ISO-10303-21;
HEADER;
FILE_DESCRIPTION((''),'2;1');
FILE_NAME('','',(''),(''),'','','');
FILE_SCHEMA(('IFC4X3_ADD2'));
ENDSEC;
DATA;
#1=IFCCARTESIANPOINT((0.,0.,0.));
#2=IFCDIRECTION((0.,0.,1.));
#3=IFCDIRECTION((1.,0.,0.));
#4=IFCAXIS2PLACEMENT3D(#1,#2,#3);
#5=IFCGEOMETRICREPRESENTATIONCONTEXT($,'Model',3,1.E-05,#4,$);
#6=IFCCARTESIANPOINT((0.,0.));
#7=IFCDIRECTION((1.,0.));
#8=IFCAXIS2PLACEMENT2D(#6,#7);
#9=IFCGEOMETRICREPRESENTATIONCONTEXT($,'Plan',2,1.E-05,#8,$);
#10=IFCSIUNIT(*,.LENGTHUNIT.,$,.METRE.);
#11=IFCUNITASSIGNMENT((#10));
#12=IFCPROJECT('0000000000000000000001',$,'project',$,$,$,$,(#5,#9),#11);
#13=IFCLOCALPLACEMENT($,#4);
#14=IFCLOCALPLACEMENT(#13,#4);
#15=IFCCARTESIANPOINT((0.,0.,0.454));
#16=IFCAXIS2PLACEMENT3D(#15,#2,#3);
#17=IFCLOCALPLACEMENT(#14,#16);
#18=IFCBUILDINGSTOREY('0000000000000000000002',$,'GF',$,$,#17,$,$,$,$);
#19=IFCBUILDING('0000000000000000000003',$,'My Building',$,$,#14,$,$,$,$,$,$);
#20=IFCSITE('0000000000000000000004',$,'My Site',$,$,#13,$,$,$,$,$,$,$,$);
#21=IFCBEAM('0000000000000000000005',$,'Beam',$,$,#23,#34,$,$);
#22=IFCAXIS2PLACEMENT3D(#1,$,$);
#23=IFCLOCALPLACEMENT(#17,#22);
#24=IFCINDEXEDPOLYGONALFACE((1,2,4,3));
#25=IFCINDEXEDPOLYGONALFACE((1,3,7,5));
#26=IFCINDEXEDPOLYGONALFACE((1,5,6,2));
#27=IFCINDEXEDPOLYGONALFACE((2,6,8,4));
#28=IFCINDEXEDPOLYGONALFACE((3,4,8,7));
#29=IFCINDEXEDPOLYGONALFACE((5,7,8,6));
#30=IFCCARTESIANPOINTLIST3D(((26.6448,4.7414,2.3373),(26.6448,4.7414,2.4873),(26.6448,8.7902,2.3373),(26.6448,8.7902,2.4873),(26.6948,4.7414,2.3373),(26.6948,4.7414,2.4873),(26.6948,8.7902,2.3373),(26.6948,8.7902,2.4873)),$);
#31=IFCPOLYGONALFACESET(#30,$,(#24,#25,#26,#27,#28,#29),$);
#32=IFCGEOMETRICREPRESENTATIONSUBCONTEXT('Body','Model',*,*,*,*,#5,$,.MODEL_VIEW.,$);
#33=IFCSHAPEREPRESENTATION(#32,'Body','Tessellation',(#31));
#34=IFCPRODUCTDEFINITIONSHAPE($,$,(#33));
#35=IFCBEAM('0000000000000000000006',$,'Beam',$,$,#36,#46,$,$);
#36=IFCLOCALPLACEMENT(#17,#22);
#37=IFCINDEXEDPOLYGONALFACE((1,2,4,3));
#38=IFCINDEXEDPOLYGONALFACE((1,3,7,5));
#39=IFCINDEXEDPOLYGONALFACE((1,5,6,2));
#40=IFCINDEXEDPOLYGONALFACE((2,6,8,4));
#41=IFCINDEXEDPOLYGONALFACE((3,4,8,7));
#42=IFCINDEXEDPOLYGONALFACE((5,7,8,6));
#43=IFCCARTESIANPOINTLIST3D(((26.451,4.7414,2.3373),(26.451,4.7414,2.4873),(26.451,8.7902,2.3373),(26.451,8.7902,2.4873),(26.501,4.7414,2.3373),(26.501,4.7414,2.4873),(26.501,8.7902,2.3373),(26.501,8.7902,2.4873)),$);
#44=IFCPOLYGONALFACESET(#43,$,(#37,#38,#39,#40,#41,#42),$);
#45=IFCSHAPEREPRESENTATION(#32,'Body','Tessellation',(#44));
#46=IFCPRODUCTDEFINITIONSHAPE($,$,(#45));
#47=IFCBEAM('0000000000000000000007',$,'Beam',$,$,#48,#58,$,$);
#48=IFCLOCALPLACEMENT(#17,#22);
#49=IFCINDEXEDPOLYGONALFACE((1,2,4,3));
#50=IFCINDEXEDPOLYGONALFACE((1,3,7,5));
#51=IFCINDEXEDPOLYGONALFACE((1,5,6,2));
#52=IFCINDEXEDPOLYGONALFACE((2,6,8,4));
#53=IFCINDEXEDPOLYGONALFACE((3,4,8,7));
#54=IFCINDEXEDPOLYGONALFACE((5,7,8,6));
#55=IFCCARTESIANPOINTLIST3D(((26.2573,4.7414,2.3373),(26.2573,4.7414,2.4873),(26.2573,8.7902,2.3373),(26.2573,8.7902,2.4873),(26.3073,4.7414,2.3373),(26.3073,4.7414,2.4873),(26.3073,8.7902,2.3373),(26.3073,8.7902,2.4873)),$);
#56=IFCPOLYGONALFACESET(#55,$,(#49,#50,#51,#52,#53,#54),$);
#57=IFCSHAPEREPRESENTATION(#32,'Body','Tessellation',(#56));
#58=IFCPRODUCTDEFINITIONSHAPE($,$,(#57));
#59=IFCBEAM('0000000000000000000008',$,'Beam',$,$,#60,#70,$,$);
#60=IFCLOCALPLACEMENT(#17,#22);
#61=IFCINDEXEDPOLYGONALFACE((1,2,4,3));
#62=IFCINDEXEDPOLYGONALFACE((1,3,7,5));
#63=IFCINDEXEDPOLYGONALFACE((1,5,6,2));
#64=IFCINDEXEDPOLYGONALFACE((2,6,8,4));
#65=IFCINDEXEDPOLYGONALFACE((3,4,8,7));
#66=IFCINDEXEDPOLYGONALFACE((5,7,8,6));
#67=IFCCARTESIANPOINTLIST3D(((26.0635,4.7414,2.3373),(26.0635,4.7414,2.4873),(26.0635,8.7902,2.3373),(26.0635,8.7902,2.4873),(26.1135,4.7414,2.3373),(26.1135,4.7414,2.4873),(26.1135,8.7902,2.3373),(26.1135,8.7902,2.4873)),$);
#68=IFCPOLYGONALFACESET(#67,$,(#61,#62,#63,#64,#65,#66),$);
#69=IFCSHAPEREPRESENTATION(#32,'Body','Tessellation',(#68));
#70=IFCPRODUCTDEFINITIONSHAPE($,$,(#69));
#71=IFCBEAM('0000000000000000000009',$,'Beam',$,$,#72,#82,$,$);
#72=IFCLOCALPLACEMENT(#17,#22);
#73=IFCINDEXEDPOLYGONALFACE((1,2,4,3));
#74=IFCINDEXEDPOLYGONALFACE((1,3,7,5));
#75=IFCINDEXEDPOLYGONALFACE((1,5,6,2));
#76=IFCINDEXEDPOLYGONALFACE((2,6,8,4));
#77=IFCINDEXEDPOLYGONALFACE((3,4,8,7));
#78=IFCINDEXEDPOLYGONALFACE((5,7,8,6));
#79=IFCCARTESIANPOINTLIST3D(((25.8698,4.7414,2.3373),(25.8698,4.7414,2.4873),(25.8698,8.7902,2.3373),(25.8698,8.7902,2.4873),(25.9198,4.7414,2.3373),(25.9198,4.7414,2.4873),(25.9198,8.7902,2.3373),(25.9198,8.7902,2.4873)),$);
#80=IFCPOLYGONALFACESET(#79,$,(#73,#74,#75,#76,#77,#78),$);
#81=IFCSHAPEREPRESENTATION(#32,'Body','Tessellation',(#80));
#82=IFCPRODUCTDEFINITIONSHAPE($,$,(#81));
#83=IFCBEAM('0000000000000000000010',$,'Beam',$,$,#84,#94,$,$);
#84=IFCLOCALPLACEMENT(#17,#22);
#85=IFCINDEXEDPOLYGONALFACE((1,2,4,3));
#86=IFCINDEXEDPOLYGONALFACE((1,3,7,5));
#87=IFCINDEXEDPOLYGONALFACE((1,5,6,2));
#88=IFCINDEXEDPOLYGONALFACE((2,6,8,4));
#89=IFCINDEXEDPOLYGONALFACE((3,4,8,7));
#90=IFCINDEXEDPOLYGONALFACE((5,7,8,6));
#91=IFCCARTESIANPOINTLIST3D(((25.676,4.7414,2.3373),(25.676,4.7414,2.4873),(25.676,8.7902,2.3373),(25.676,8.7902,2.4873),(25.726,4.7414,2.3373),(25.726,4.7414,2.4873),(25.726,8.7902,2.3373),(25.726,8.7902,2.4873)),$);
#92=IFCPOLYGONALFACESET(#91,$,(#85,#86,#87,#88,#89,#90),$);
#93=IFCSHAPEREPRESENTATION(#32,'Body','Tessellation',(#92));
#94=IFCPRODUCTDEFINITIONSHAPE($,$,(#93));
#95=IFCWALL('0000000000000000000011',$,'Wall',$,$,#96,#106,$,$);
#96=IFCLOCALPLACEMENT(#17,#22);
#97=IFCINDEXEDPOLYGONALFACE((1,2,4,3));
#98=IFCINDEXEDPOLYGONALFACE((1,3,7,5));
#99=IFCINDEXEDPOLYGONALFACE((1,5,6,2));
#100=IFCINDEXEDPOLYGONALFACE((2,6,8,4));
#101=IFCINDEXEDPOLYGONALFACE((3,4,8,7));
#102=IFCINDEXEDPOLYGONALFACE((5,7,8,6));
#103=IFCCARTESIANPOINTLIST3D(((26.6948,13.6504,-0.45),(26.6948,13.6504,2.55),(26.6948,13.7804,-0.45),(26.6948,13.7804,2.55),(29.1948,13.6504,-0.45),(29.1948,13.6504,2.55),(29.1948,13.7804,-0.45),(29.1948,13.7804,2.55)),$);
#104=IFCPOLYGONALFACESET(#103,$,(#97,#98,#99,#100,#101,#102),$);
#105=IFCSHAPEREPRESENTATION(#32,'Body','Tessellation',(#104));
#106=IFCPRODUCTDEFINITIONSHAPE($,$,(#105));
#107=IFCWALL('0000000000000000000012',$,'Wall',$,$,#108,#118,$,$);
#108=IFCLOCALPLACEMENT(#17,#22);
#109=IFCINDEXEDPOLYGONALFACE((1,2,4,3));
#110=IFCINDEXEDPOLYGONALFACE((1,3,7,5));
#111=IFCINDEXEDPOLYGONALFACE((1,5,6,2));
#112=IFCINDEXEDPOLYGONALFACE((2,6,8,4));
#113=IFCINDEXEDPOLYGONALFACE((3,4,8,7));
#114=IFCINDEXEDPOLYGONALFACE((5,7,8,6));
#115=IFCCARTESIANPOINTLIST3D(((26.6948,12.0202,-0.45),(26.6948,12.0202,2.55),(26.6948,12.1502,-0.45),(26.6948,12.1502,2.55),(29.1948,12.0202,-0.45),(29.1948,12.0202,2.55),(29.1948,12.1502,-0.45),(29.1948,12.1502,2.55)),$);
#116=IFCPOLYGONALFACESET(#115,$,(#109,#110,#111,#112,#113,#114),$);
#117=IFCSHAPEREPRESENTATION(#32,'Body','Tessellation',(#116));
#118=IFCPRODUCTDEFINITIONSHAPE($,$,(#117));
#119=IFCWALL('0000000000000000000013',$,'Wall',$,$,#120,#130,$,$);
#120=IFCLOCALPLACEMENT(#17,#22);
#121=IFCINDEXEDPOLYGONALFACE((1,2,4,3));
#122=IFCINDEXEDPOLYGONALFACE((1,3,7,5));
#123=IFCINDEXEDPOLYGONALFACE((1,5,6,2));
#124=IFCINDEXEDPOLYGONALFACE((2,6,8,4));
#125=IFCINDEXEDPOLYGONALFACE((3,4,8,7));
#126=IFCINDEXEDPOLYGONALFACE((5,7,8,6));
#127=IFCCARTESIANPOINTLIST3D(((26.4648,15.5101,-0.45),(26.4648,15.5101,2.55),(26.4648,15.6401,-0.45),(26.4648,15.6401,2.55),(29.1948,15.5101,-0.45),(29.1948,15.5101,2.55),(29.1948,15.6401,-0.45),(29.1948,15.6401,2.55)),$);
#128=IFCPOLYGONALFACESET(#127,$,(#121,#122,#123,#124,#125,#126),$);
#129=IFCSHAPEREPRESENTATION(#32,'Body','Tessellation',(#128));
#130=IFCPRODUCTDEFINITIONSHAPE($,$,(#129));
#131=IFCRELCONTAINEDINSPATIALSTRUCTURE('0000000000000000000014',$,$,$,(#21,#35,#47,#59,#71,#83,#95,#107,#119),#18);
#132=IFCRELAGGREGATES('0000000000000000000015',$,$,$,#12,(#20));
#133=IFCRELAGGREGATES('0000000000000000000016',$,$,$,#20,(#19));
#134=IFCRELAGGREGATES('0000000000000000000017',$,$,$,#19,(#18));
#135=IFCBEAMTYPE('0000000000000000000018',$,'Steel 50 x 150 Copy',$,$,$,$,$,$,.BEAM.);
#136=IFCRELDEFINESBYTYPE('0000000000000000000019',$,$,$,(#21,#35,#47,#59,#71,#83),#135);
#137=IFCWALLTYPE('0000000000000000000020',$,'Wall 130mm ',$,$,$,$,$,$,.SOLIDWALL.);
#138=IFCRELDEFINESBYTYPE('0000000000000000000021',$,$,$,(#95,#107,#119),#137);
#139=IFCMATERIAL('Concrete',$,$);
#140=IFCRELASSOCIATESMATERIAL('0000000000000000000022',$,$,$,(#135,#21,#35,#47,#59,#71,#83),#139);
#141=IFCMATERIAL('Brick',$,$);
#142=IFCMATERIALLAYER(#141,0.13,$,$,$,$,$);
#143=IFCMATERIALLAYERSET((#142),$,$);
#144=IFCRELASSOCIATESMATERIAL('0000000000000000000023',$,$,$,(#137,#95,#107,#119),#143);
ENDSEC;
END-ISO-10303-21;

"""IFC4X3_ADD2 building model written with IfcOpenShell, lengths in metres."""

from ifc_helpers import new_model, si_unit, frame, origin_with_axes, origin_2d_with_axis, place, context, subcontext, project, spatial, indexed_curve, rectangle, outline, extrude, material, layer, layer_set, layer_usage, material_profile, profile_set, profile_usage, type_object, element, save


model = new_model("IFC4X3_ADD2")

# Units and contexts
model_context = context("Model", 3, precision=1e-05, world=origin_with_axes())
plan_context = context("Plan", 2, precision=1e-05, world=origin_2d_with_axis())
body_context_1 = subcontext(model_context, "Body", "Model", "MODEL_VIEW")
ifc_project = project(units=[si_unit("LENGTHUNIT", "METRE")], contexts=[model_context, plan_context])

# Site, building, storey
site_placement = place(None, origin_with_axes())
site = spatial("IfcSite", under=ifc_project, at=site_placement, Name="My Site")
building_placement = place(site_placement, origin_with_axes())
building = spatial("IfcBuilding", under=site, at=building_placement, Name="My Building")
storey_placement = place(building_placement, frame((0.0, 0.0, 0.454), z_axis=(0.0, 0.0, 1.0), x_axis=(1.0, 0.0, 0.0)))
storey = spatial("IfcBuildingStorey", under=building, at=storey_placement, Name="GF")

# Beams
ifc_material_1 = material(Name="Concrete")
ifc_material_profile = material_profile(ifc_material_1, rectangle(XDim=0.05, YDim=0.15))
ifc_profile_set = profile_set([ifc_material_profile])
ifc_profile_usage_1 = profile_usage(ifc_profile_set)
beam_type = type_object("IfcBeamType", Name="Steel 50 x 150 Copy", PredefinedType="BEAM", material=ifc_profile_set)
beam_1_placement = place(storey_placement, frame((26.6698, 8.7902, 2.4123), z_axis=(0.0, -1.0, 0.0), x_axis=(1.0, 0.0, 0.0)))
element("IfcBeam", 1, at=beam_1_placement, inside=storey, type_object=beam_type, material=ifc_profile_usage_1, Name="Beam", context=body_context_1, shape_type="SweptSolid", body=[
    extrude(rectangle(XDim=0.05, YDim=0.15), origin_with_axes(), (0.0, 0.0, 1.0), 4.0488),
])
ifc_profile_usage_2 = profile_usage(ifc_profile_set)
beam_2_placement = place(storey_placement, frame((26.476, 8.7902, 2.4123), z_axis=(0.0, -1.0, 0.0), x_axis=(1.0, 0.0, 0.0)))
element("IfcBeam", 2, at=beam_2_placement, inside=storey, type_object=beam_type, material=ifc_profile_usage_2, Name="Beam", context=body_context_1, shape_type="SweptSolid", body=[
    extrude(rectangle(XDim=0.05, YDim=0.15), origin_with_axes(), (0.0, 0.0, 1.0), 4.0488),
])
ifc_profile_usage_3 = profile_usage(ifc_profile_set)
beam_3_placement = place(storey_placement, frame((26.2823, 8.7902, 2.4123), z_axis=(0.0, -1.0, 0.0), x_axis=(1.0, 0.0, 0.0)))
element("IfcBeam", 3, at=beam_3_placement, inside=storey, type_object=beam_type, material=ifc_profile_usage_3, Name="Beam", context=body_context_1, shape_type="SweptSolid", body=[
    extrude(rectangle(XDim=0.05, YDim=0.15), origin_with_axes(), (0.0, 0.0, 1.0), 4.0488),
])
ifc_profile_usage_4 = profile_usage(ifc_profile_set)
beam_4_placement = place(storey_placement, frame((26.0885, 8.7902, 2.4123), z_axis=(0.0, -1.0, 0.0), x_axis=(1.0, 0.0, 0.0)))
element("IfcBeam", 4, at=beam_4_placement, inside=storey, type_object=beam_type, material=ifc_profile_usage_4, Name="Beam", context=body_context_1, shape_type="SweptSolid", body=[
    extrude(rectangle(XDim=0.05, YDim=0.15), origin_with_axes(), (0.0, 0.0, 1.0), 4.0488),
])
ifc_profile_usage_5 = profile_usage(ifc_profile_set)
beam_5_placement = place(storey_placement, frame((25.8948, 8.7902, 2.4123), z_axis=(0.0, -1.0, 0.0), x_axis=(1.0, 0.0, 0.0)))
element("IfcBeam", 5, at=beam_5_placement, inside=storey, type_object=beam_type, material=ifc_profile_usage_5, Name="Beam", context=body_context_1, shape_type="SweptSolid", body=[
    extrude(rectangle(XDim=0.05, YDim=0.15), origin_with_axes(), (0.0, 0.0, 1.0), 4.0488),
])
ifc_profile_usage_6 = profile_usage(ifc_profile_set)
beam_6_placement = place(storey_placement, frame((25.701, 8.7902, 2.4123), z_axis=(0.0, -1.0, 0.0), x_axis=(1.0, 0.0, 0.0)))
element("IfcBeam", 6, at=beam_6_placement, inside=storey, type_object=beam_type, material=ifc_profile_usage_6, Name="Beam", context=body_context_1, shape_type="SweptSolid", body=[
    extrude(rectangle(XDim=0.05, YDim=0.15), origin_with_axes(), (0.0, 0.0, 1.0), 4.0488),
])

# Walls
ifc_material_2 = material(Name="Brick")
ifc_layer_1 = layer(ifc_material_2, 0.13)
ifc_layer_set_1 = layer_set([ifc_layer_1])
ifc_layer_usage_1 = layer_usage(ifc_layer_set_1, "AXIS2", "POSITIVE", 0.0)
wall_type_1 = type_object("IfcWallType", Name="Wall 130mm ", PredefinedType="SOLIDWALL", material=ifc_layer_set_1)
wall_1_placement = place(storey_placement, frame((29.1948, 13.7804, -0.45), z_axis=(0.0, 0.0, 1.0), x_axis=(-1.0, 0.0, 0.0)))
element("IfcWall", 7, at=wall_1_placement, inside=storey, type_object=wall_type_1, material=ifc_layer_usage_1, Name="Wall", context=body_context_1, shape_type="SweptSolid", body=[
    extrude(outline(indexed_curve([(0.0, 0.0), (0.0, 0.13), (2.5, 0.13), (2.5, 0.0), (0.0, 0.0)], self_intersect=False)), origin_with_axes(), (0.0, 0.0, 1.0), 3.0),
])
ifc_layer_usage_2 = layer_usage(ifc_layer_set_1, "AXIS2", "POSITIVE", 0.0)
wall_2_placement = place(storey_placement, frame((29.1948, 12.1502, -0.45), z_axis=(0.0, 0.0, 1.0), x_axis=(-1.0, 0.0, 0.0)))
element("IfcWall", 8, at=wall_2_placement, inside=storey, type_object=wall_type_1, material=ifc_layer_usage_2, Name="Wall", context=body_context_1, shape_type="SweptSolid", body=[
    extrude(outline(indexed_curve([(0.0, 0.0), (0.0, 0.13), (2.5, 0.13), (2.5, 0.0), (0.0, 0.0)], self_intersect=False)), origin_with_axes(), (0.0, 0.0, 1.0), 3.0),
])
ifc_layer_usage_3 = layer_usage(ifc_layer_set_1, "AXIS2", "POSITIVE", 0.0)
wall_3_placement = place(storey_placement, frame((29.1948, 15.6401, -0.45), z_axis=(0.0, 0.0, 1.0), x_axis=(-1.0, 0.0, 0.0)))
element("IfcWall", 9, at=wall_3_placement, inside=storey, type_object=wall_type_1, material=ifc_layer_usage_3, Name="Wall", context=body_context_1, shape_type="SweptSolid", body=[
    extrude(outline(indexed_curve([(0.0, 0.0), (0.0, 0.13), (2.73, 0.13), (2.73, 0.0), (0.0, 0.0)], self_intersect=False)), origin_with_axes(), (0.0, 0.0, 1.0), 3.0),
])

save(model, "model.ifc")
